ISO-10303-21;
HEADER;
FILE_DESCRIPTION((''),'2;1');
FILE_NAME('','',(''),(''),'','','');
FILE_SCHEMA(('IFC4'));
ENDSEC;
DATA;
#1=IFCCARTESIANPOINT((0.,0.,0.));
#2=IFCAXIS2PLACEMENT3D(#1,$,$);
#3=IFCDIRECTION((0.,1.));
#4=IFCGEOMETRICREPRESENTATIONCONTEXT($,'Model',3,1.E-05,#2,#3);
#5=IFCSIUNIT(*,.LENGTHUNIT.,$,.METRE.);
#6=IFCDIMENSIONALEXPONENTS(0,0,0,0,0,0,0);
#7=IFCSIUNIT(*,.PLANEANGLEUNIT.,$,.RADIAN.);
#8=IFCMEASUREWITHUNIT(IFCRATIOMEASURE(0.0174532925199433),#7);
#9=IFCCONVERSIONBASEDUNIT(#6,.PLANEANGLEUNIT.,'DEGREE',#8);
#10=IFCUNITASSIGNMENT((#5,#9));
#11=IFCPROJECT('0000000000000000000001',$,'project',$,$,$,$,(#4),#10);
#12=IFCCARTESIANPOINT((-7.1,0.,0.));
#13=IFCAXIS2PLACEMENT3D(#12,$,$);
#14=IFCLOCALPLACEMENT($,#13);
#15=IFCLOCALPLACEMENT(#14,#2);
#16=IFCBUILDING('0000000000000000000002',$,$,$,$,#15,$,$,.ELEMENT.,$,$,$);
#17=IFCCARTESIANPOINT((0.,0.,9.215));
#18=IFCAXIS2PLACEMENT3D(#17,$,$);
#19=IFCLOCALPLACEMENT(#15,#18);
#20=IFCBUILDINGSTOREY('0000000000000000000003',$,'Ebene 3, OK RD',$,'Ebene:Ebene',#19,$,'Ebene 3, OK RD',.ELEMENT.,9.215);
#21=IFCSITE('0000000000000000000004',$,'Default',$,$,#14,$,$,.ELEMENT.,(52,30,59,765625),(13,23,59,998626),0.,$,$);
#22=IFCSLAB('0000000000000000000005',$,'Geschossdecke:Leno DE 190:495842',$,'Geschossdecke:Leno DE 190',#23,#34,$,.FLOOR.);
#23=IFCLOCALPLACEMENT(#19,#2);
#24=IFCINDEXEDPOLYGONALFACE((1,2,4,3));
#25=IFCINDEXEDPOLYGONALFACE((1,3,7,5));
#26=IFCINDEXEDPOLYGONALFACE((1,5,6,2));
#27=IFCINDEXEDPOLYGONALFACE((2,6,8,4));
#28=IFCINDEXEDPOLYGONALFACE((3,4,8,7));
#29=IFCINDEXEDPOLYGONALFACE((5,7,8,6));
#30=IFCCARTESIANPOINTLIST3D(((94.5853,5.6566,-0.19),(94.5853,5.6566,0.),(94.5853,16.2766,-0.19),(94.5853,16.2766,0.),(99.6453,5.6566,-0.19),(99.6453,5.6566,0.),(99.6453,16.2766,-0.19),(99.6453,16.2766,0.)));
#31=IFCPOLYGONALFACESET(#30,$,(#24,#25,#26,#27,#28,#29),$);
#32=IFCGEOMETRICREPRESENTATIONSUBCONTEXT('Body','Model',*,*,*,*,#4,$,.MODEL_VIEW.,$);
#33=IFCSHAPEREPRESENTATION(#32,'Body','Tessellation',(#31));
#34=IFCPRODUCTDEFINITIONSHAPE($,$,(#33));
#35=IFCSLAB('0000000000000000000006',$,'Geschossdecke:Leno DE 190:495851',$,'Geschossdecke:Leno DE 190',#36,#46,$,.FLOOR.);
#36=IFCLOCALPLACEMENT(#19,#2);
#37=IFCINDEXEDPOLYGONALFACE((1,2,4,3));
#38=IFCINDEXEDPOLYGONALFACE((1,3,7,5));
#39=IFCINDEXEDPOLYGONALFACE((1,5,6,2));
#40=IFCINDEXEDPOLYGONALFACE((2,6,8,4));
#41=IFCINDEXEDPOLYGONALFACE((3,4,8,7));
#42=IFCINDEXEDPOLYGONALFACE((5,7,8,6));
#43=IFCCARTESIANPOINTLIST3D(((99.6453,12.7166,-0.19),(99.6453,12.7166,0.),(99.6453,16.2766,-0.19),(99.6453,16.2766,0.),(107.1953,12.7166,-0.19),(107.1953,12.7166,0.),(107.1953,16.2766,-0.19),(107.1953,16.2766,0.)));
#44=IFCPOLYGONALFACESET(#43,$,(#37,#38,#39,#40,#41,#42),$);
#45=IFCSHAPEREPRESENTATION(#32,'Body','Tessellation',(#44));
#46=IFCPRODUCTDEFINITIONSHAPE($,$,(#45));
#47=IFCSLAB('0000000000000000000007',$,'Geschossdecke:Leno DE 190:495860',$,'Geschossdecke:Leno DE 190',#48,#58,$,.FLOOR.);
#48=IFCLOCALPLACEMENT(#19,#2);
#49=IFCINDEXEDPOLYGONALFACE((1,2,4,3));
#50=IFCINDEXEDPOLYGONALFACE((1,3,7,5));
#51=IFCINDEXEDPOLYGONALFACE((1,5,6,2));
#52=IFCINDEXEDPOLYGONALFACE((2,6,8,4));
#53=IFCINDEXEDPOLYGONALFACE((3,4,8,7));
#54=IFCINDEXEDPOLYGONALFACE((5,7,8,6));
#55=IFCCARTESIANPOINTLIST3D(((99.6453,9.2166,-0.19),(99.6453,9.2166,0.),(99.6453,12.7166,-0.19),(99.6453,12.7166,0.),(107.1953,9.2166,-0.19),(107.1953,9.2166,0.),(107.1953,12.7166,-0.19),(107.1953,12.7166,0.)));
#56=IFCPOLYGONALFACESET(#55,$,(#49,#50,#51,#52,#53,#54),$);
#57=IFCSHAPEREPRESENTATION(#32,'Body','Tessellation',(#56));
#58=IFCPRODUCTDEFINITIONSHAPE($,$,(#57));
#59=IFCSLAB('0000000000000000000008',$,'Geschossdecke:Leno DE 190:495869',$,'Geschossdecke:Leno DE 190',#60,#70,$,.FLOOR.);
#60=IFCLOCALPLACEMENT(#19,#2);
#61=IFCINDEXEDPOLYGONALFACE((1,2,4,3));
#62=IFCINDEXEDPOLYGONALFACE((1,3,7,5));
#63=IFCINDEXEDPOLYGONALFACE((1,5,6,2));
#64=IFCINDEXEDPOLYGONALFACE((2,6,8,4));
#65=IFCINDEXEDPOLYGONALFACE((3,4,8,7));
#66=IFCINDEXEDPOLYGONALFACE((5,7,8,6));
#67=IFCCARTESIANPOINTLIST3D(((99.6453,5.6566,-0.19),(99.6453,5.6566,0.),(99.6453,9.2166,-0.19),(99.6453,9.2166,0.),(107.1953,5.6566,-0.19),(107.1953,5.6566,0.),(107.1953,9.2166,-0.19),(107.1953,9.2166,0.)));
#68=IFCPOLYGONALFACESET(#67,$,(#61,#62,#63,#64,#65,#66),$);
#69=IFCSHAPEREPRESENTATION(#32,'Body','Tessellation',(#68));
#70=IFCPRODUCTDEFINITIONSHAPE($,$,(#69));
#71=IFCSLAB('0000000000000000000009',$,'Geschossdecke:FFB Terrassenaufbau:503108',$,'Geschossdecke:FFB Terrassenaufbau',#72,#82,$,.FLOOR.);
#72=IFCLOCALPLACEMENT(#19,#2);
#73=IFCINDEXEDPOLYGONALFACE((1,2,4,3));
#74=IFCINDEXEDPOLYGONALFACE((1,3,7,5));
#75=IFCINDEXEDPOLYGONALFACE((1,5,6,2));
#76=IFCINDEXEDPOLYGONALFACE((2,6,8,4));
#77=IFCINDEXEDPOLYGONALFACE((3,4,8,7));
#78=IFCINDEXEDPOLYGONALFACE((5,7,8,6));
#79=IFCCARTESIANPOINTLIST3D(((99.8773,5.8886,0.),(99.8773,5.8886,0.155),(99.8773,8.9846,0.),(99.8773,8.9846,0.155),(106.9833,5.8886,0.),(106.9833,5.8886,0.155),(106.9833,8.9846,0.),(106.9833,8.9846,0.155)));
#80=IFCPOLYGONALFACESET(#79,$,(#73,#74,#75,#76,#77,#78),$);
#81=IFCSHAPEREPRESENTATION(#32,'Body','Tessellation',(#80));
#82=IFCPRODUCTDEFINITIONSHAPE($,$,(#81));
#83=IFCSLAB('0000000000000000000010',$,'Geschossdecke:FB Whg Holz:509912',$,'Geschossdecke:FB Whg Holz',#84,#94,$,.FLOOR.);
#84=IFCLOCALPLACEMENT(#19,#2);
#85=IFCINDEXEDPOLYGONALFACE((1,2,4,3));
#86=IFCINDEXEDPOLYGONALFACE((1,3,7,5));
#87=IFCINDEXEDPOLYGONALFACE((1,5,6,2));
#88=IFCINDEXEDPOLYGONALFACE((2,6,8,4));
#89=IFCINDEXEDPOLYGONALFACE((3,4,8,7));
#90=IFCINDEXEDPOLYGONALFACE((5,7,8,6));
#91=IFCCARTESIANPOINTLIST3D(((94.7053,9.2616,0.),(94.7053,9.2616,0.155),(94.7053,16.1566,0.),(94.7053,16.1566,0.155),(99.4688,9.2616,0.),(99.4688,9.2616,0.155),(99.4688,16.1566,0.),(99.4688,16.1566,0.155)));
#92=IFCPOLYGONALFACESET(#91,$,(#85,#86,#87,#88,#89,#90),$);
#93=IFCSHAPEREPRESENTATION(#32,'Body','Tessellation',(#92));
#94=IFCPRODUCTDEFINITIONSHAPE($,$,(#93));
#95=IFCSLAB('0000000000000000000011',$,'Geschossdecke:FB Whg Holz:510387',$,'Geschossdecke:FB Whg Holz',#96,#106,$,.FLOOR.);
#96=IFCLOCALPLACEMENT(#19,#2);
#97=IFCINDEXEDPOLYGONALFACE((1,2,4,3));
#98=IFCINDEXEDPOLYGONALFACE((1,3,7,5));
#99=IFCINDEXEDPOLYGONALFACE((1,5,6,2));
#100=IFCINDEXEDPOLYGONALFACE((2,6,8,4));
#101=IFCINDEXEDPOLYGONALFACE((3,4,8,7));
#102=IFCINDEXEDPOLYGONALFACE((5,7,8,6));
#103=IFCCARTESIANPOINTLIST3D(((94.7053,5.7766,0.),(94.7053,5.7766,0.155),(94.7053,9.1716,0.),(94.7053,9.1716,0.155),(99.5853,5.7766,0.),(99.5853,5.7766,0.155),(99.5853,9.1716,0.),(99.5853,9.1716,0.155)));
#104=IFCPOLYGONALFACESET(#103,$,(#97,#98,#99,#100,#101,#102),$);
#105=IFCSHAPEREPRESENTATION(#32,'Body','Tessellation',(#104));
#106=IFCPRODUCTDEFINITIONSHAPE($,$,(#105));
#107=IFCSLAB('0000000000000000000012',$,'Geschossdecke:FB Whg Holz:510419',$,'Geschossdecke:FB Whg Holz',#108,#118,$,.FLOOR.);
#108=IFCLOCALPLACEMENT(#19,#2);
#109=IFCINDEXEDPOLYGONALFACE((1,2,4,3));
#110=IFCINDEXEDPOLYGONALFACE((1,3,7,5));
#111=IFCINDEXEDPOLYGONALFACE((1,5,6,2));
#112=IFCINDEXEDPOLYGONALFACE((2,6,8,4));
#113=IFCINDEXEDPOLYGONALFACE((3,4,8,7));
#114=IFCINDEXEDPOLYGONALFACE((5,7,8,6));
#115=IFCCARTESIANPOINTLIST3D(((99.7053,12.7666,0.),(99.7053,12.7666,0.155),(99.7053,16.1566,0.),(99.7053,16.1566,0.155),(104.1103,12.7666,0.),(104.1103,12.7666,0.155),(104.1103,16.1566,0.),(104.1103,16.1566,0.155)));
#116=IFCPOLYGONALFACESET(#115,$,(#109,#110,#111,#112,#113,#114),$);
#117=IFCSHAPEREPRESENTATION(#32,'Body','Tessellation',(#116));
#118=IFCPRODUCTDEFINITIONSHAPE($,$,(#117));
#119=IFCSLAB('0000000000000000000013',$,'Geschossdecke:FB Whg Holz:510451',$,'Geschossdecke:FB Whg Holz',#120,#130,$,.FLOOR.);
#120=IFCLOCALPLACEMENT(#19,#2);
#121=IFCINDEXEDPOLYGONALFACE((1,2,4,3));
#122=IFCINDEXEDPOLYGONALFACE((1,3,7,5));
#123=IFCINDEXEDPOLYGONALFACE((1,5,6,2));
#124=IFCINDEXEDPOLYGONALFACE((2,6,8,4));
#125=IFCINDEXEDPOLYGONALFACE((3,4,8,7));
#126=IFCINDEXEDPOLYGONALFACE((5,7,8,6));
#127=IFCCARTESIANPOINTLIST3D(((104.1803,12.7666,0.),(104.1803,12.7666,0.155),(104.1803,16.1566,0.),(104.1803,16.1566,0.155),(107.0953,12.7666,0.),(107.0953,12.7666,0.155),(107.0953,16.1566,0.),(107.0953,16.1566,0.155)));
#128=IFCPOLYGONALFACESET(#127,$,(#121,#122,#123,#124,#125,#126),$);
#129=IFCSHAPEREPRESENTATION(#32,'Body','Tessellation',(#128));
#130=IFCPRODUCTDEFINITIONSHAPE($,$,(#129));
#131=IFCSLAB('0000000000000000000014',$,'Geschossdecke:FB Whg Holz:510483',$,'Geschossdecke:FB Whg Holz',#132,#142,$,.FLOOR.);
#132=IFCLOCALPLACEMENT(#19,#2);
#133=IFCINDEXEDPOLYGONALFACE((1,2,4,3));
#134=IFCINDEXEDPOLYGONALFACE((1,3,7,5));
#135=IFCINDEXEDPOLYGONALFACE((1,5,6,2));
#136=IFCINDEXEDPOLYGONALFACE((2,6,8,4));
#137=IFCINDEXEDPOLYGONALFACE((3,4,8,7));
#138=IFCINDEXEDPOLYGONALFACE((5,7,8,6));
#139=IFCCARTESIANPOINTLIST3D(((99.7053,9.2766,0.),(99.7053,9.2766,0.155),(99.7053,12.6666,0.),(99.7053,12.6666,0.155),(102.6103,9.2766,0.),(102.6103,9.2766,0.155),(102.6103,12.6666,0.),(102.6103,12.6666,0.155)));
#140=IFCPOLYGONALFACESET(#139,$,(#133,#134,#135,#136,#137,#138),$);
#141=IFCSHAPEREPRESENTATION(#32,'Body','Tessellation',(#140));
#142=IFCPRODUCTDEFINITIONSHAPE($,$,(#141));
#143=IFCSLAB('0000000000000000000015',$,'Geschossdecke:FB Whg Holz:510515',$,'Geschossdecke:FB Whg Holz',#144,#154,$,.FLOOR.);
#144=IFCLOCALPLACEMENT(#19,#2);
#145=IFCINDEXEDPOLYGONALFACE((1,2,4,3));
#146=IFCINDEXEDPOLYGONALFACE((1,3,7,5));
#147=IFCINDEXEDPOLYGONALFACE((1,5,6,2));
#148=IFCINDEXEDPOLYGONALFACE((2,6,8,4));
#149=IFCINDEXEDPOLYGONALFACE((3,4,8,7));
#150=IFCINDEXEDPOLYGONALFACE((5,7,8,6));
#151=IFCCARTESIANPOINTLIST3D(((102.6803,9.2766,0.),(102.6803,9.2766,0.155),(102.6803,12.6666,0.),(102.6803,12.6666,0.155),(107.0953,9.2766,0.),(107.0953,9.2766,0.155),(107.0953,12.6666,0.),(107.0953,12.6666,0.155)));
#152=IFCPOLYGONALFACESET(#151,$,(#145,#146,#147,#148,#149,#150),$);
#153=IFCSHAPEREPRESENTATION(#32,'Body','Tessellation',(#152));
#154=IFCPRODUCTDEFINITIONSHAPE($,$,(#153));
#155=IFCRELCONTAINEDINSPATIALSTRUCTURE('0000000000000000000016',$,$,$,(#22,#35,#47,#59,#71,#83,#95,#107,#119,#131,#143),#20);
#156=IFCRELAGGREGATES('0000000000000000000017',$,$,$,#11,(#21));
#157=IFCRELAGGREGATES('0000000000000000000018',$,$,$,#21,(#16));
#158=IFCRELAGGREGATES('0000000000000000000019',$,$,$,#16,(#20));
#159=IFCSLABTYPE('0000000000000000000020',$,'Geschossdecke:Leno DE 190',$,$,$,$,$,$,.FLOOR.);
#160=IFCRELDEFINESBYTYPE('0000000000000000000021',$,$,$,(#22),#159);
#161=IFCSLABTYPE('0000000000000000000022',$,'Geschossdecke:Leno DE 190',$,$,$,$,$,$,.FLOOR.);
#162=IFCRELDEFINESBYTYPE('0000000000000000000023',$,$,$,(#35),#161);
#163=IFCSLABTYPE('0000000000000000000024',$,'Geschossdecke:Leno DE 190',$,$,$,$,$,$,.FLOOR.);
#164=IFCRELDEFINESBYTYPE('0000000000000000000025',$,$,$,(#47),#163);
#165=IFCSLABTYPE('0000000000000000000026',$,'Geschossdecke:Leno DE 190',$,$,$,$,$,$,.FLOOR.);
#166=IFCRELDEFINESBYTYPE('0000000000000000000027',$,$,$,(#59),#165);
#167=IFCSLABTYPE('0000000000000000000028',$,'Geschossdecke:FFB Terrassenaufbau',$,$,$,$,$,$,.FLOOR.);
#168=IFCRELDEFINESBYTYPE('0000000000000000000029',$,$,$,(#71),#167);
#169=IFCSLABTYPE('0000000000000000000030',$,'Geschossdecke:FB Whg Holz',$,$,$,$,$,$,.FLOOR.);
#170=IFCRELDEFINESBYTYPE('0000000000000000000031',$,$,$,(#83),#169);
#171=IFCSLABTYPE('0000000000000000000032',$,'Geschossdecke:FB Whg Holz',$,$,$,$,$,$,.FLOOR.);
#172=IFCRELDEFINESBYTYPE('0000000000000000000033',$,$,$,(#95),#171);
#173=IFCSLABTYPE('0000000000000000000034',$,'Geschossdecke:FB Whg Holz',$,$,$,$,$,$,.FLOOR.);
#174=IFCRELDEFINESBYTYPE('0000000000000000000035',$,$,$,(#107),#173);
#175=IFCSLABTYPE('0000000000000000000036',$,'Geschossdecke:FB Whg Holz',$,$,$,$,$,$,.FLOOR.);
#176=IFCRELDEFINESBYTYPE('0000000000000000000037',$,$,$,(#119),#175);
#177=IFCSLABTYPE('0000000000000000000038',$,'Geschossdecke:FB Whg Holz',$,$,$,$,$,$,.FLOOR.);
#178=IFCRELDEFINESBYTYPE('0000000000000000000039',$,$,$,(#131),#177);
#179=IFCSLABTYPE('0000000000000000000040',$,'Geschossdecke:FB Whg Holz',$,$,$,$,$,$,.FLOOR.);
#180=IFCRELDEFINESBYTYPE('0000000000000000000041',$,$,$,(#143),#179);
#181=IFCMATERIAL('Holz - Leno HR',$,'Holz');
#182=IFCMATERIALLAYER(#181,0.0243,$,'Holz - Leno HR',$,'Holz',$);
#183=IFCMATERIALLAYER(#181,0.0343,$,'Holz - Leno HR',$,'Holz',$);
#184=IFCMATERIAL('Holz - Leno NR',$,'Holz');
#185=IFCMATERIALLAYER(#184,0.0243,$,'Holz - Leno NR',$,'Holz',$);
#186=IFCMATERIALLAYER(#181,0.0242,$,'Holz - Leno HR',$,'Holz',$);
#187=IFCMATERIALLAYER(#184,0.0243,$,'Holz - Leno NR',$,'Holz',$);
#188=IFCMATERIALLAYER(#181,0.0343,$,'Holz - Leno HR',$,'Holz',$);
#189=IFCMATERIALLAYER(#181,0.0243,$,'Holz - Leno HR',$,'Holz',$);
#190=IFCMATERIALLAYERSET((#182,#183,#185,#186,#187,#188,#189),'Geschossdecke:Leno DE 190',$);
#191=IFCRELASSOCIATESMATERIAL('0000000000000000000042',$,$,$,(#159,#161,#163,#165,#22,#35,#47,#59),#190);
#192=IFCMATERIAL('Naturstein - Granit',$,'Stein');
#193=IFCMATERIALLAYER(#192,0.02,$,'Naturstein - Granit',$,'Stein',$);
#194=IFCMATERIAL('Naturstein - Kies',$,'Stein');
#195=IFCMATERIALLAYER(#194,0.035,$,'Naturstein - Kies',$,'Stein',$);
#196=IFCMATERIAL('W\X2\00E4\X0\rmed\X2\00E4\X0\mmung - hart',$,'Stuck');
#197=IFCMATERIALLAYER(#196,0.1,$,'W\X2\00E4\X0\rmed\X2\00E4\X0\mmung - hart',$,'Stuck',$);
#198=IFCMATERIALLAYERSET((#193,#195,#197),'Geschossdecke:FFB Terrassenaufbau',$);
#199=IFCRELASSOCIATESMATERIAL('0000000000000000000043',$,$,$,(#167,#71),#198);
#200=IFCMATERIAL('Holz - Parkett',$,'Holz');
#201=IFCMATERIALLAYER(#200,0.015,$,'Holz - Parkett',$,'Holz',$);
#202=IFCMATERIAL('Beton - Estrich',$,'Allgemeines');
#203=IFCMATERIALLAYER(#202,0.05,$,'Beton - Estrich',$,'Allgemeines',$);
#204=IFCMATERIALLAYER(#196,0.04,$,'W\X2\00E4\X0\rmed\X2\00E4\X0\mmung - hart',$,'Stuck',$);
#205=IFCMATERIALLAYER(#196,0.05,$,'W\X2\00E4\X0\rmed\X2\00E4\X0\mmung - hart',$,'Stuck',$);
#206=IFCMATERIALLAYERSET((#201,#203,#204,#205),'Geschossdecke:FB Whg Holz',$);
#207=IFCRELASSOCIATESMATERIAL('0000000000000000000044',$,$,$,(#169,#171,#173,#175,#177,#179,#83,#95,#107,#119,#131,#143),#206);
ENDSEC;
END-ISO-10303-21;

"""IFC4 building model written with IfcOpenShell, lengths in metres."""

from ifc_helpers import new_model, entity, si_unit, converted_unit, direction, frame, frame_2d, origin, place, context, subcontext, project, spatial, rectangle, extrude, material, layer, layer_set, layer_usage, type_object, element, save


model = new_model("IFC4")

# Units and contexts
model_context = context("Model", 3, precision=1e-05, world=origin(), true_north=direction((0.0, 1.0)))
body_context = subcontext(model_context, "Body", "Model", "MODEL_VIEW")
ifc_project = project(units=[si_unit("LENGTHUNIT", "METRE"), converted_unit("PLANEANGLEUNIT", "DEGREE", entity("IfcRatioMeasure", 0.0174532925199433), si_unit("PLANEANGLEUNIT", "RADIAN"), dimensions=[0, 0, 0, 0, 0, 0, 0])], contexts=[model_context])

# Site, building, storey
site_placement = place(None, frame((-7.1, 0.0, 0.0)))
site = spatial("IfcSite", under=ifc_project, at=site_placement, Name="Default", CompositionType="ELEMENT", RefLatitude=(52, 30, 59, 765625), RefLongitude=(13, 23, 59, 998626), RefElevation=0.0)
building_placement = place(site_placement, origin())
building = spatial("IfcBuilding", under=site, at=building_placement, CompositionType="ELEMENT")
storey_placement = place(building_placement, frame((0.0, 0.0, 9.215)))
storey = spatial("IfcBuildingStorey", under=building, at=storey_placement, Name="Ebene 3, OK RD", ObjectType="Ebene:Ebene", LongName="Ebene 3, OK RD", CompositionType="ELEMENT", Elevation=9.215)

# Slabs
ifc_material_1 = material(Name="Holz - Leno HR", Category="Holz")
ifc_layer_1 = layer(ifc_material_1, 0.0243, Name="Holz - Leno HR", Category="Holz")
ifc_layer_2 = layer(ifc_material_1, 0.0343, Name="Holz - Leno HR", Category="Holz")
ifc_material_2 = material(Name="Holz - Leno NR", Category="Holz")
ifc_layer_3 = layer(ifc_material_2, 0.0243, Name="Holz - Leno NR", Category="Holz")
ifc_layer_4 = layer(ifc_material_1, 0.0242, Name="Holz - Leno HR", Category="Holz")
ifc_layer_5 = layer(ifc_material_2, 0.0243, Name="Holz - Leno NR", Category="Holz")
ifc_layer_6 = layer(ifc_material_1, 0.0343, Name="Holz - Leno HR", Category="Holz")
ifc_layer_7 = layer(ifc_material_1, 0.0243, Name="Holz - Leno HR", Category="Holz")
ifc_layer_set_1 = layer_set([ifc_layer_1, ifc_layer_2, ifc_layer_3, ifc_layer_4, ifc_layer_5, ifc_layer_6, ifc_layer_7], Name="Geschossdecke:Leno DE 190")
ifc_layer_usage_1 = layer_usage(ifc_layer_set_1, "AXIS3", "POSITIVE", 0.0)
slab_type_1 = type_object("IfcSlabType", Name="Geschossdecke:Leno DE 190", PredefinedType="FLOOR", material=ifc_layer_set_1)
slab_1_placement = place(storey_placement, origin())
element("IfcSlab", 1, at=slab_1_placement, inside=storey, type_object=slab_type_1, material=ifc_layer_usage_1, Name="Geschossdecke:Leno DE 190:495842", ObjectType="Geschossdecke:Leno DE 190", PredefinedType="FLOOR", context=body_context, shape_type="SweptSolid", body=[
    extrude(rectangle(XDim=10.62, YDim=5.06, at=frame_2d((0.0, 0.0), x_axis=(1.0, 0.0))), frame((97.1153, 10.9666, 0.0), z_axis=(0.0, 0.0, -1.0), x_axis=(0.0, 1.0, 0.0)), (0.0, 0.0, 1.0), 0.19),
])
ifc_layer_usage_2 = layer_usage(ifc_layer_set_1, "AXIS3", "POSITIVE", 0.0)
slab_type_2 = type_object("IfcSlabType", Name="Geschossdecke:Leno DE 190", PredefinedType="FLOOR", material=ifc_layer_set_1)
slab_2_placement = place(storey_placement, origin())
element("IfcSlab", 2, at=slab_2_placement, inside=storey, type_object=slab_type_2, material=ifc_layer_usage_2, Name="Geschossdecke:Leno DE 190:495851", ObjectType="Geschossdecke:Leno DE 190", PredefinedType="FLOOR", context=body_context, shape_type="SweptSolid", body=[
    extrude(rectangle(XDim=3.56, YDim=7.55, at=frame_2d((0.0, 0.0), x_axis=(1.0, 0.0))), frame((103.4203, 14.4966, 0.0), z_axis=(0.0, 0.0, -1.0), x_axis=(0.0, 1.0, 0.0)), (0.0, 0.0, 1.0), 0.19),
])
ifc_layer_usage_3 = layer_usage(ifc_layer_set_1, "AXIS3", "POSITIVE", 0.0)
slab_type_3 = type_object("IfcSlabType", Name="Geschossdecke:Leno DE 190", PredefinedType="FLOOR", material=ifc_layer_set_1)
slab_3_placement = place(storey_placement, origin())
element("IfcSlab", 3, at=slab_3_placement, inside=storey, type_object=slab_type_3, material=ifc_layer_usage_3, Name="Geschossdecke:Leno DE 190:495860", ObjectType="Geschossdecke:Leno DE 190", PredefinedType="FLOOR", context=body_context, shape_type="SweptSolid", body=[
    extrude(rectangle(XDim=3.5, YDim=7.55, at=frame_2d((0.0, 0.0), x_axis=(1.0, 0.0))), frame((103.4203, 10.9666, 0.0), z_axis=(0.0, 0.0, -1.0), x_axis=(0.0, 1.0, 0.0)), (0.0, 0.0, 1.0), 0.19),
])
ifc_layer_usage_4 = layer_usage(ifc_layer_set_1, "AXIS3", "POSITIVE", 0.0)
slab_type_4 = type_object("IfcSlabType", Name="Geschossdecke:Leno DE 190", PredefinedType="FLOOR", material=ifc_layer_set_1)
slab_4_placement = place(storey_placement, origin())
element("IfcSlab", 4, at=slab_4_placement, inside=storey, type_object=slab_type_4, material=ifc_layer_usage_4, Name="Geschossdecke:Leno DE 190:495869", ObjectType="Geschossdecke:Leno DE 190", PredefinedType="FLOOR", context=body_context, shape_type="SweptSolid", body=[
    extrude(rectangle(XDim=3.56, YDim=7.55, at=frame_2d((0.0, 0.0), x_axis=(1.0, 0.0))), frame((103.4203, 7.4366, 0.0), z_axis=(0.0, 0.0, -1.0), x_axis=(0.0, 1.0, 0.0)), (0.0, 0.0, 1.0), 0.19),
])
ifc_material_3 = material(Name="Naturstein - Granit", Category="Stein")
ifc_layer_8 = layer(ifc_material_3, 0.02, Name="Naturstein - Granit", Category="Stein")
ifc_material_4 = material(Name="Naturstein - Kies", Category="Stein")
ifc_layer_9 = layer(ifc_material_4, 0.035, Name="Naturstein - Kies", Category="Stein")
ifc_material_5 = material(Name="Wärmedämmung - hart", Category="Stuck")
ifc_layer_10 = layer(ifc_material_5, 0.1, Name="Wärmedämmung - hart", Category="Stuck")
ifc_layer_set_2 = layer_set([ifc_layer_8, ifc_layer_9, ifc_layer_10], Name="Geschossdecke:FFB Terrassenaufbau")
ifc_layer_usage_5 = layer_usage(ifc_layer_set_2, "AXIS3", "POSITIVE", 0.0)
slab_type_5 = type_object("IfcSlabType", Name="Geschossdecke:FFB Terrassenaufbau", PredefinedType="FLOOR", material=ifc_layer_set_2)
slab_5_placement = place(storey_placement, origin())
element("IfcSlab", 5, at=slab_5_placement, inside=storey, type_object=slab_type_5, material=ifc_layer_usage_5, Name="Geschossdecke:FFB Terrassenaufbau:503108", ObjectType="Geschossdecke:FFB Terrassenaufbau", PredefinedType="FLOOR", context=body_context, shape_type="SweptSolid", body=[
    extrude(rectangle(XDim=3.096, YDim=7.106, at=frame_2d((0.0, 0.0), x_axis=(1.0, 0.0))), frame((103.4303, 7.4366, 0.155), z_axis=(0.0, 0.0, -1.0), x_axis=(0.0, 1.0, 0.0)), (0.0, 0.0, 1.0), 0.155),
])
ifc_material_6 = material(Name="Holz - Parkett", Category="Holz")
ifc_layer_11 = layer(ifc_material_6, 0.015, Name="Holz - Parkett", Category="Holz")
ifc_material_7 = material(Name="Beton - Estrich", Category="Allgemeines")
ifc_layer_12 = layer(ifc_material_7, 0.05, Name="Beton - Estrich", Category="Allgemeines")
ifc_layer_13 = layer(ifc_material_5, 0.04, Name="Wärmedämmung - hart", Category="Stuck")
ifc_layer_14 = layer(ifc_material_5, 0.05, Name="Wärmedämmung - hart", Category="Stuck")
ifc_layer_set_3 = layer_set([ifc_layer_11, ifc_layer_12, ifc_layer_13, ifc_layer_14], Name="Geschossdecke:FB Whg Holz")
ifc_layer_usage_6 = layer_usage(ifc_layer_set_3, "AXIS3", "POSITIVE", 0.0)
slab_type_6 = type_object("IfcSlabType", Name="Geschossdecke:FB Whg Holz", PredefinedType="FLOOR", material=ifc_layer_set_3)
slab_6_placement = place(storey_placement, origin())
element("IfcSlab", 6, at=slab_6_placement, inside=storey, type_object=slab_type_6, material=ifc_layer_usage_6, Name="Geschossdecke:FB Whg Holz:509912", ObjectType="Geschossdecke:FB Whg Holz", PredefinedType="FLOOR", context=body_context, shape_type="SweptSolid", body=[
    extrude(rectangle(XDim=6.895, YDim=4.7635, at=frame_2d((0.0, 0.0), x_axis=(1.0, 0.0))), frame((97.0871, 12.7091, 0.155), z_axis=(0.0, 0.0, -1.0), x_axis=(0.0, 1.0, 0.0)), (0.0, 0.0, 1.0), 0.155),
])
ifc_layer_usage_7 = layer_usage(ifc_layer_set_3, "AXIS3", "POSITIVE", 0.0)
slab_type_7 = type_object("IfcSlabType", Name="Geschossdecke:FB Whg Holz", PredefinedType="FLOOR", material=ifc_layer_set_3)
slab_7_placement = place(storey_placement, origin())
element("IfcSlab", 7, at=slab_7_placement, inside=storey, type_object=slab_type_7, material=ifc_layer_usage_7, Name="Geschossdecke:FB Whg Holz:510387", ObjectType="Geschossdecke:FB Whg Holz", PredefinedType="FLOOR", context=body_context, shape_type="SweptSolid", body=[
    extrude(rectangle(XDim=3.395, YDim=4.88, at=frame_2d((0.0, 0.0), x_axis=(1.0, 0.0))), frame((97.1453, 7.4741, 0.155), z_axis=(0.0, 0.0, -1.0), x_axis=(0.0, 1.0, 0.0)), (0.0, 0.0, 1.0), 0.155),
])
ifc_layer_usage_8 = layer_usage(ifc_layer_set_3, "AXIS3", "POSITIVE", 0.0)
slab_type_8 = type_object("IfcSlabType", Name="Geschossdecke:FB Whg Holz", PredefinedType="FLOOR", material=ifc_layer_set_3)
slab_8_placement = place(storey_placement, origin())
element("IfcSlab", 8, at=slab_8_placement, inside=storey, type_object=slab_type_8, material=ifc_layer_usage_8, Name="Geschossdecke:FB Whg Holz:510419", ObjectType="Geschossdecke:FB Whg Holz", PredefinedType="FLOOR", context=body_context, shape_type="SweptSolid", body=[
    extrude(rectangle(XDim=3.39, YDim=4.405, at=frame_2d((0.0, 0.0), x_axis=(1.0, 0.0))), frame((101.9078, 14.4616, 0.155), z_axis=(0.0, 0.0, -1.0), x_axis=(0.0, 1.0, 0.0)), (0.0, 0.0, 1.0), 0.155),
])
ifc_layer_usage_9 = layer_usage(ifc_layer_set_3, "AXIS3", "POSITIVE", 0.0)
slab_type_9 = type_object("IfcSlabType", Name="Geschossdecke:FB Whg Holz", PredefinedType="FLOOR", material=ifc_layer_set_3)
slab_9_placement = place(storey_placement, origin())
element("IfcSlab", 9, at=slab_9_placement, inside=storey, type_object=slab_type_9, material=ifc_layer_usage_9, Name="Geschossdecke:FB Whg Holz:510451", ObjectType="Geschossdecke:FB Whg Holz", PredefinedType="FLOOR", context=body_context, shape_type="SweptSolid", body=[
    extrude(rectangle(XDim=3.39, YDim=2.915, at=frame_2d((0.0, 0.0), x_axis=(1.0, 0.0))), frame((105.6378, 14.4616, 0.155), z_axis=(0.0, 0.0, -1.0), x_axis=(0.0, 1.0, 0.0)), (0.0, 0.0, 1.0), 0.155),
])
ifc_layer_usage_10 = layer_usage(ifc_layer_set_3, "AXIS3", "POSITIVE", 0.0)
slab_type_10 = type_object("IfcSlabType", Name="Geschossdecke:FB Whg Holz", PredefinedType="FLOOR", material=ifc_layer_set_3)
slab_10_placement = place(storey_placement, origin())
element("IfcSlab", 10, at=slab_10_placement, inside=storey, type_object=slab_type_10, material=ifc_layer_usage_10, Name="Geschossdecke:FB Whg Holz:510483", ObjectType="Geschossdecke:FB Whg Holz", PredefinedType="FLOOR", context=body_context, shape_type="SweptSolid", body=[
    extrude(rectangle(XDim=3.39, YDim=2.905, at=frame_2d((0.0, 0.0), x_axis=(1.0, 0.0))), frame((101.1578, 10.9716, 0.155), z_axis=(0.0, 0.0, -1.0), x_axis=(0.0, 1.0, 0.0)), (0.0, 0.0, 1.0), 0.155),
])
ifc_layer_usage_11 = layer_usage(ifc_layer_set_3, "AXIS3", "POSITIVE", 0.0)
slab_type_11 = type_object("IfcSlabType", Name="Geschossdecke:FB Whg Holz", PredefinedType="FLOOR", material=ifc_layer_set_3)
slab_11_placement = place(storey_placement, origin())
element("IfcSlab", 11, at=slab_11_placement, inside=storey, type_object=slab_type_11, material=ifc_layer_usage_11, Name="Geschossdecke:FB Whg Holz:510515", ObjectType="Geschossdecke:FB Whg Holz", PredefinedType="FLOOR", context=body_context, shape_type="SweptSolid", body=[
    extrude(rectangle(XDim=3.39, YDim=4.415, at=frame_2d((0.0, 0.0), x_axis=(1.0, 0.0))), frame((104.8878, 10.9716, 0.155), z_axis=(0.0, 0.0, -1.0), x_axis=(0.0, 1.0, 0.0)), (0.0, 0.0, 1.0), 0.155),
])

save(model, "model.ifc")
